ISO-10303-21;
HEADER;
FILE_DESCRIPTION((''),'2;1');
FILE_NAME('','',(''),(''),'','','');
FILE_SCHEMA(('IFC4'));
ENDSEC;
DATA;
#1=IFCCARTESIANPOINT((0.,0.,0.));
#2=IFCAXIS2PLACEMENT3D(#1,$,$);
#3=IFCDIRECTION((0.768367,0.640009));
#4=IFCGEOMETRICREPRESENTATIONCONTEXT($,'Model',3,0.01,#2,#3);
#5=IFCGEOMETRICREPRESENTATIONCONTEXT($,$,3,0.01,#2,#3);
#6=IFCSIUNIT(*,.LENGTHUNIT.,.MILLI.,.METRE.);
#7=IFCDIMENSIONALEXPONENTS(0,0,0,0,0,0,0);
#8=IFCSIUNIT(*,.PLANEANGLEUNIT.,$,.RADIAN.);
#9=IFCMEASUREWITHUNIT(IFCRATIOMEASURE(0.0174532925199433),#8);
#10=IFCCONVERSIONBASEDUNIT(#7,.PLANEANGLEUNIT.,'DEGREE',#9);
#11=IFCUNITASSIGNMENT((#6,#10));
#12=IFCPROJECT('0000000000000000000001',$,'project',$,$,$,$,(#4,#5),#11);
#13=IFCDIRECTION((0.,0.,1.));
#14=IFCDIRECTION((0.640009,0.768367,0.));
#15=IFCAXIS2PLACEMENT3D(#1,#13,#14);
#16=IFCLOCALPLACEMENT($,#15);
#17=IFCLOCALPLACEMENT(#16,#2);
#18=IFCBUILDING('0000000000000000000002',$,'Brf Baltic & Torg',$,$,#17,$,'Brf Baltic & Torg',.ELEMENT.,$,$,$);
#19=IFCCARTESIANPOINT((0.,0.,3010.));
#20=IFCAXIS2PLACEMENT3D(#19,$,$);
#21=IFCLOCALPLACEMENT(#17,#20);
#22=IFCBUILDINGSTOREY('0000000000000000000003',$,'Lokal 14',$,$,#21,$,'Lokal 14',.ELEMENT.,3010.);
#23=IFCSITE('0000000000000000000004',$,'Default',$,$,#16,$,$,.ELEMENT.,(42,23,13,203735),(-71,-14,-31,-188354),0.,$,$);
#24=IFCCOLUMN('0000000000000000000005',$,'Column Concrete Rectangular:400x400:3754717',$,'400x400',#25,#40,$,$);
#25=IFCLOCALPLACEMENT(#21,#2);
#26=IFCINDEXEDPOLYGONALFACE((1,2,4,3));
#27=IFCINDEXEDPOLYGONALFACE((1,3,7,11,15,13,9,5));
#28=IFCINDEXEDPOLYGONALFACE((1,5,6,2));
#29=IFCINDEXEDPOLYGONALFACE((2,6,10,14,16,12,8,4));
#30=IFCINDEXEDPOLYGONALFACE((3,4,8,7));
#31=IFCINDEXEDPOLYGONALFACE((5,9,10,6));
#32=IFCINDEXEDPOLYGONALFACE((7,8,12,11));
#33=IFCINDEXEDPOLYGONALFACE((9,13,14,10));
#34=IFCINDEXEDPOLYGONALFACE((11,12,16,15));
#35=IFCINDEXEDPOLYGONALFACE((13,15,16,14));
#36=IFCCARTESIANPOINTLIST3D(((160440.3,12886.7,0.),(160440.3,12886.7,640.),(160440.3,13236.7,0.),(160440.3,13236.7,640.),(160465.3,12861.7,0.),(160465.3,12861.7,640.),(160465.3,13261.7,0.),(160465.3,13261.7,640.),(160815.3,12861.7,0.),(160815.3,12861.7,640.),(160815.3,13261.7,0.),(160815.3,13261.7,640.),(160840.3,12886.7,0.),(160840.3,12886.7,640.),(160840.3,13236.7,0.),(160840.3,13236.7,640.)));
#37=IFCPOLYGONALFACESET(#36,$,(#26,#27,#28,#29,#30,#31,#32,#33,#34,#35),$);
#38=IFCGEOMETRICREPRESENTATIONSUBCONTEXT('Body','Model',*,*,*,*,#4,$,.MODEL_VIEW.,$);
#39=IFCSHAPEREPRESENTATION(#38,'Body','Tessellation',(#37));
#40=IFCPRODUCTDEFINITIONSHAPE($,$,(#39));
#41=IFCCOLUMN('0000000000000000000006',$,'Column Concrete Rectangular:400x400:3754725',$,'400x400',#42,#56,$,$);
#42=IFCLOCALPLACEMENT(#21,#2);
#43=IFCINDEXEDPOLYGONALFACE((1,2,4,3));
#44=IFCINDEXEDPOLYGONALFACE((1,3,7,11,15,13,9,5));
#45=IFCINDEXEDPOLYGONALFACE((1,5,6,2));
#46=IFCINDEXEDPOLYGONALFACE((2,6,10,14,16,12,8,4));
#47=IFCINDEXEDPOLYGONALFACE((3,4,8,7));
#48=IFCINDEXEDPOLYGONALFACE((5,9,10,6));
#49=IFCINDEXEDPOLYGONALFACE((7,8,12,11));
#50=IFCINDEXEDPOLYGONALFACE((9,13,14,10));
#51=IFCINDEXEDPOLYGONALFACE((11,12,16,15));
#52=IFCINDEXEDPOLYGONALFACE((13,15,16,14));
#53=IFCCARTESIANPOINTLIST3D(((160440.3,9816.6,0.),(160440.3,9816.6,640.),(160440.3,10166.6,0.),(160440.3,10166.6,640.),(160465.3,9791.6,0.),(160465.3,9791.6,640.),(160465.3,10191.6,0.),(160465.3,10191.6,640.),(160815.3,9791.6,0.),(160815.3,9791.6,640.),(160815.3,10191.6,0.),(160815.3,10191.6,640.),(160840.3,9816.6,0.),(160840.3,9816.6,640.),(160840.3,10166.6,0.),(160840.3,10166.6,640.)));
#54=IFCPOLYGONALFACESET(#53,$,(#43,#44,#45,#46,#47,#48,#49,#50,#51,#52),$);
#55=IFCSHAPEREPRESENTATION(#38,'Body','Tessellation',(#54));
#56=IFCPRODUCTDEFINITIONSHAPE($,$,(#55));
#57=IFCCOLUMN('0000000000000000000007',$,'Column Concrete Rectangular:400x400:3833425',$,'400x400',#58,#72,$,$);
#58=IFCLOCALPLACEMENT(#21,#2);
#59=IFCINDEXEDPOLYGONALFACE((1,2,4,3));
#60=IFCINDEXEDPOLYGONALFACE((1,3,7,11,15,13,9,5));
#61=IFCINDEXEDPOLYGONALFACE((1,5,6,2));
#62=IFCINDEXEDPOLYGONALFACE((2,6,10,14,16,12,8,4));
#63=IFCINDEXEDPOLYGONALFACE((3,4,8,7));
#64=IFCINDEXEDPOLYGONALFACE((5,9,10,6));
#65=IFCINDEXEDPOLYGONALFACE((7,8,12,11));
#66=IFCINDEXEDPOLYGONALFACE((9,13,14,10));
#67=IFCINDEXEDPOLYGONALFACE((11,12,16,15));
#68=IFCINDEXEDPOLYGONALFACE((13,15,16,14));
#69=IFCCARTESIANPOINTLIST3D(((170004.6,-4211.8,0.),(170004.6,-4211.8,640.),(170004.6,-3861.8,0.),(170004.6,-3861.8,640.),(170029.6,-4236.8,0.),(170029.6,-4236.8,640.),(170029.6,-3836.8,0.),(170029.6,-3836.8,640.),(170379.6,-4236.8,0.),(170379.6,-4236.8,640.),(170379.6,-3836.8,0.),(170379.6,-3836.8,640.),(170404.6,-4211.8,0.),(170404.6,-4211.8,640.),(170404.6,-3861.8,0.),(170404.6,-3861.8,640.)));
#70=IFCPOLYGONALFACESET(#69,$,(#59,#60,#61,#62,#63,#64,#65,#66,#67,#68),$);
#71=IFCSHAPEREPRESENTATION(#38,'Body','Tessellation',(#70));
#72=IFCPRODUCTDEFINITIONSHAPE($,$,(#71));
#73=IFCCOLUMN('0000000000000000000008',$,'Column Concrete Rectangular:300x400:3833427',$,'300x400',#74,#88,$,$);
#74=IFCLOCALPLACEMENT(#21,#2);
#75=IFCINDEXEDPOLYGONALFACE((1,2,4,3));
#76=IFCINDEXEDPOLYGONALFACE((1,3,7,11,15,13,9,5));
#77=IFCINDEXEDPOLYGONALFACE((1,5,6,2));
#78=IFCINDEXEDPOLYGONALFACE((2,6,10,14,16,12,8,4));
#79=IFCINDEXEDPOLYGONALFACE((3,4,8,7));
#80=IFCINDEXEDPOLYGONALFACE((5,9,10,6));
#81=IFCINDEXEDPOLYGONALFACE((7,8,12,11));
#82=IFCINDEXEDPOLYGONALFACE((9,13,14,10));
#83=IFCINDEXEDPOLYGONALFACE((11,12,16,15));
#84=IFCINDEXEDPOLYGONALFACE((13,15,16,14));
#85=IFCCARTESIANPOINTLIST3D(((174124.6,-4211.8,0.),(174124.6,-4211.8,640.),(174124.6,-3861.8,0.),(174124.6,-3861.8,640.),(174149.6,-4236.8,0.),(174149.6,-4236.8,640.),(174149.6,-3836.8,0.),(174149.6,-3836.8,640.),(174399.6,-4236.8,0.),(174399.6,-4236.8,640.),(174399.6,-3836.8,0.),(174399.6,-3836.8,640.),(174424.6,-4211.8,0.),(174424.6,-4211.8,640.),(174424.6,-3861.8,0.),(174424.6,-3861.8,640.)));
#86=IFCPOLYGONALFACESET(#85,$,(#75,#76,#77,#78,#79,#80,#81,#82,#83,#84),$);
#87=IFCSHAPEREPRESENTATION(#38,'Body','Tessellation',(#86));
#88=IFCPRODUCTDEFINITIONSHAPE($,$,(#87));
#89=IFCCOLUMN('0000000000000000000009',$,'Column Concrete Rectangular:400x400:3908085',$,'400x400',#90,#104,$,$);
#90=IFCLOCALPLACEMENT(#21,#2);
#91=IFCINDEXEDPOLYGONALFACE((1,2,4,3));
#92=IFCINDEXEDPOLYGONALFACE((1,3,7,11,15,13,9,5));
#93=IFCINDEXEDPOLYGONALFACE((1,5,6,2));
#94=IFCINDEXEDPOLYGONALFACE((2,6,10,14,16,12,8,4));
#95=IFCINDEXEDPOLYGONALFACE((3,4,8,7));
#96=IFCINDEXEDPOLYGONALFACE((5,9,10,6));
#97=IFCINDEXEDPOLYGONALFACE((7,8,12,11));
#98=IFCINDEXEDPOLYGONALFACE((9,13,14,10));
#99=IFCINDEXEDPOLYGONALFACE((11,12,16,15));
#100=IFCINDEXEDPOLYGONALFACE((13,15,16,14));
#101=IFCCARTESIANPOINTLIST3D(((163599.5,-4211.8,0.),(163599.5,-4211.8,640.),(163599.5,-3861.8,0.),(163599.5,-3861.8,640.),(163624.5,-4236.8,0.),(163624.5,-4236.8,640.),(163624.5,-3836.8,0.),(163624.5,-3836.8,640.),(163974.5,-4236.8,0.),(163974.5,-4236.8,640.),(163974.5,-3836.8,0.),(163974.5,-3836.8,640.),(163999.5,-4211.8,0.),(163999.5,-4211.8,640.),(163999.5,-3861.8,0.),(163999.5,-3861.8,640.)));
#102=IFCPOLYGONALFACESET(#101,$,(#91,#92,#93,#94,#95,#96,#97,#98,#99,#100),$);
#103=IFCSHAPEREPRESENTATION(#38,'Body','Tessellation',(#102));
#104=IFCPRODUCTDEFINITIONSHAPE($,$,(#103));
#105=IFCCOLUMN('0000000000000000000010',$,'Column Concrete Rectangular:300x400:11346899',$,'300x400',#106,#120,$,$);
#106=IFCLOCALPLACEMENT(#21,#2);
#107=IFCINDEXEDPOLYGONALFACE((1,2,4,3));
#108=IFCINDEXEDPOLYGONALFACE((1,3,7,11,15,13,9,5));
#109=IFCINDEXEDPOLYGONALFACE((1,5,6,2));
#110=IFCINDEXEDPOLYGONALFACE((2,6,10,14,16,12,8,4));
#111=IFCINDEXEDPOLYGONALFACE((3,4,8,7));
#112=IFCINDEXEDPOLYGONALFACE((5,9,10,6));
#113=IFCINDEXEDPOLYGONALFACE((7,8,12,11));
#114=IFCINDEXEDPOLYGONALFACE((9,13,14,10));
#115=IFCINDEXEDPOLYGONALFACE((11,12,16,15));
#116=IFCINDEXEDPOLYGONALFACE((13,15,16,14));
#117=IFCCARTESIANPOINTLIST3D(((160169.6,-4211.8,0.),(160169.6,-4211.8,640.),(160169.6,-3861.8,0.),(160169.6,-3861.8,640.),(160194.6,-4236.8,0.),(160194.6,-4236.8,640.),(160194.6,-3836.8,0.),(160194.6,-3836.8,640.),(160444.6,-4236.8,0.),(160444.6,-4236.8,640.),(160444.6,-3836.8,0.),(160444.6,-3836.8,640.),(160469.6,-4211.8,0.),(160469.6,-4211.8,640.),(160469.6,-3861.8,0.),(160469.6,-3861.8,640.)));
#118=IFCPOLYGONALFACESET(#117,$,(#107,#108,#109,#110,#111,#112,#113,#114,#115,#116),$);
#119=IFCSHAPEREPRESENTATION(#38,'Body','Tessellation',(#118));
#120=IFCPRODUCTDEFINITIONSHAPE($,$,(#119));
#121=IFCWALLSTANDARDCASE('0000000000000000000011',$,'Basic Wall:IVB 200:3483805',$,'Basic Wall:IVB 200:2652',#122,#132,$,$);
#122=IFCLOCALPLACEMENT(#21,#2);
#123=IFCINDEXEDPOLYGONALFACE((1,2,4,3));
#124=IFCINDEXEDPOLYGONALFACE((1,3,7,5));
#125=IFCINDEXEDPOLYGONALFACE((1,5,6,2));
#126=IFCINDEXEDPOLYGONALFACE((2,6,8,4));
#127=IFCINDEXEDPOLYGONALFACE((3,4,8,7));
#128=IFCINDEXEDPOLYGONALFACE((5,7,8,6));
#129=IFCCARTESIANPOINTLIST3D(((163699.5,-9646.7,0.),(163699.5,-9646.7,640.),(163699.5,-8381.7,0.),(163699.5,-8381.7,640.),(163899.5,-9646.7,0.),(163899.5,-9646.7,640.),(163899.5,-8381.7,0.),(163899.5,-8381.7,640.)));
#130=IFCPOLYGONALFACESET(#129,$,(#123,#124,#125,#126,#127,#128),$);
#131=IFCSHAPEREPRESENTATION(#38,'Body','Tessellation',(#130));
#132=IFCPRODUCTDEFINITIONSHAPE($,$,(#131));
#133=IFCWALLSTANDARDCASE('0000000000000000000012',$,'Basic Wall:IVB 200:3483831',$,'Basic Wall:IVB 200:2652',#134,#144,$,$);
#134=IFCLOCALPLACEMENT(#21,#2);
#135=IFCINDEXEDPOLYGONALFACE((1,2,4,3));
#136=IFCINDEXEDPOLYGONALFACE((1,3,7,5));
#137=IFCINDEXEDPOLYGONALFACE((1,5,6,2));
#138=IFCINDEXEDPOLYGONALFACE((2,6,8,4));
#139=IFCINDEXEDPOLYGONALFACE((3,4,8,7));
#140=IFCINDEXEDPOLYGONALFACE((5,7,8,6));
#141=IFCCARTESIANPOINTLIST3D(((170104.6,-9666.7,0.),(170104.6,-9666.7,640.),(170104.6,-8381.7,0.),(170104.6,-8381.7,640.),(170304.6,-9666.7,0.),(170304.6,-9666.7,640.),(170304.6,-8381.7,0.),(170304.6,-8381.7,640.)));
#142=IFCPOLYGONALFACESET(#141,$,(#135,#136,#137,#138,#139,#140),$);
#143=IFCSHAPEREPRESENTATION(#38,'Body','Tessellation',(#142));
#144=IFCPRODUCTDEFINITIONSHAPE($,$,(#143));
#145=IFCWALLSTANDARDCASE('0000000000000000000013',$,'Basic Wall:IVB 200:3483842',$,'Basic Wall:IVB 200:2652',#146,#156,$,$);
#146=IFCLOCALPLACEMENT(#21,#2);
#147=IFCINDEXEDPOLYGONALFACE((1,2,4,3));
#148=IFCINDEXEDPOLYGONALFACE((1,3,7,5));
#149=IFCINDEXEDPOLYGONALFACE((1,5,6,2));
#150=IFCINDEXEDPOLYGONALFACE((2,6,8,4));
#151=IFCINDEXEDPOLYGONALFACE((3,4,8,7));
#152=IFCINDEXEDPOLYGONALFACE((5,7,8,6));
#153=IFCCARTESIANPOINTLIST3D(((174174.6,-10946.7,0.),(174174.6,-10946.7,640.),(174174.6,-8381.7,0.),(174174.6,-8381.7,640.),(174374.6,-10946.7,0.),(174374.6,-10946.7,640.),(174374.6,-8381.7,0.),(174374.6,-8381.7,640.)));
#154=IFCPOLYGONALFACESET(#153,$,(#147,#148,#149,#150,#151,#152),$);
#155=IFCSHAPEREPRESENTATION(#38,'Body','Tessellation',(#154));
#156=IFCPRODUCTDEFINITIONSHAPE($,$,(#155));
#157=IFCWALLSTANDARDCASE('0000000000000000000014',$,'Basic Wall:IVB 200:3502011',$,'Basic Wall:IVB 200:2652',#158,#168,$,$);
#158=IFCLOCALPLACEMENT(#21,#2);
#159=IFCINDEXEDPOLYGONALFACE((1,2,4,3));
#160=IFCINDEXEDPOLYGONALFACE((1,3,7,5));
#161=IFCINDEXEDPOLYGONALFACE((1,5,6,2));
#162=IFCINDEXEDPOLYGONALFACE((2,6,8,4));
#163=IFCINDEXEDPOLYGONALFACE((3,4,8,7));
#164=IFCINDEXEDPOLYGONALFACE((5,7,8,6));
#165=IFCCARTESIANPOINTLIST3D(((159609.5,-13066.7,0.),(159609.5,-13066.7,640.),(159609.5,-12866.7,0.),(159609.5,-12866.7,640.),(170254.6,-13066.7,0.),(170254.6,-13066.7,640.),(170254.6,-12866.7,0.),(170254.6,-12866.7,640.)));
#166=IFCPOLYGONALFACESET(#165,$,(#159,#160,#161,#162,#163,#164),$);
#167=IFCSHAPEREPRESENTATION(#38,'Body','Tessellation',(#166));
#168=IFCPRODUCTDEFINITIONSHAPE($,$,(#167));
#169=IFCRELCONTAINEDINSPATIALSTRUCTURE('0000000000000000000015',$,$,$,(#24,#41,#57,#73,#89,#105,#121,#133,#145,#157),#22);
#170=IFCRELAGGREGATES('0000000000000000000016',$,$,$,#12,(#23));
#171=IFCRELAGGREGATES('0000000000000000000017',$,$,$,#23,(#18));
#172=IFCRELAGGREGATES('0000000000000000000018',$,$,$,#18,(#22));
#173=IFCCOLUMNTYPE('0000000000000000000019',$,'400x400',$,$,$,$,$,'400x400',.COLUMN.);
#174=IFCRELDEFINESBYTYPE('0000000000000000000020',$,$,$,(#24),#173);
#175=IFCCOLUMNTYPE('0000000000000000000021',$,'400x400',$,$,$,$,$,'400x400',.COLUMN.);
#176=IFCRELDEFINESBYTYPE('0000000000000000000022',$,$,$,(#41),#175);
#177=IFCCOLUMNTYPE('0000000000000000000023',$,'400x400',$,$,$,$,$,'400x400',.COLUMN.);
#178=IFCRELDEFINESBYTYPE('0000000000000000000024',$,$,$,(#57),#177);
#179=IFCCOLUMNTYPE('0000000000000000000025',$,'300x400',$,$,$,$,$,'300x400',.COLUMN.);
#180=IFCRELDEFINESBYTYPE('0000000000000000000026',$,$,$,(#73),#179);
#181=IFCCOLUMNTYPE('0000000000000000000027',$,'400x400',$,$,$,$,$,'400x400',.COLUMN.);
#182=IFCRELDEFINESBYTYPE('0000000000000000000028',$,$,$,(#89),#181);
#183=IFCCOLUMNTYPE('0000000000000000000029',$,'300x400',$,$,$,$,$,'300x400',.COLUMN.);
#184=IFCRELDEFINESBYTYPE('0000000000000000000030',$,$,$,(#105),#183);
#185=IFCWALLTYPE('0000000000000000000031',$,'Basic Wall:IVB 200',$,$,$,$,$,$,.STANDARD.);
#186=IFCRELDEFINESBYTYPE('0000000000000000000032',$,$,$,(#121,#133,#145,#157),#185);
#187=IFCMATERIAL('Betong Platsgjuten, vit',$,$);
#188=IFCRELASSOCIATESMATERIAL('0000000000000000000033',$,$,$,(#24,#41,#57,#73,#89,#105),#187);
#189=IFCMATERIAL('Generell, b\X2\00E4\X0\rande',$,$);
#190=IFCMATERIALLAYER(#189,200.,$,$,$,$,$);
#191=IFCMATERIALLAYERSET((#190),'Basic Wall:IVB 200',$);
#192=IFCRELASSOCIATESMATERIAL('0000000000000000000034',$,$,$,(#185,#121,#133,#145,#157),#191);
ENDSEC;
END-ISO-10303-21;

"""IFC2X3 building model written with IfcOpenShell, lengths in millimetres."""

from ifc_helpers import new_model, entity, si_unit, converted_unit, direction, frame, frame_2d, origin, place, context, subcontext, project, spatial, polyline, rectangle, outline, extrude, clip, halfspace, source, transform, mapped, material, layer, layer_set, layer_usage, type_object, type_shapes, element, save


model = new_model("IFC2X3")

# Units and contexts
model_context = context("Model", 3, precision=0.01, world=origin(), true_north=direction((0.768367, 0.640009)))
context_of_model = context(None, 3, precision=0.01, world=origin(), true_north=direction((0.768367, 0.640009)))
body_context = subcontext(model_context, "Body", "Model", "MODEL_VIEW")
ifc_project = project(units=[si_unit("LENGTHUNIT", "METRE", prefix="MILLI"), converted_unit("PLANEANGLEUNIT", "DEGREE", entity("IfcRatioMeasure", 0.0174532925199433), si_unit("PLANEANGLEUNIT", "RADIAN"), dimensions=[0, 0, 0, 0, 0, 0, 0])], contexts=[model_context, context_of_model])

# Site, building, storey
site_placement = place(None, frame((0.0, 0.0, 0.0), z_axis=(0.0, 0.0, 1.0), x_axis=(0.640009, 0.768367, 0.0)))
site = spatial("IfcSite", under=ifc_project, at=site_placement, Name="Default", CompositionType="ELEMENT", RefLatitude=(42, 23, 13, 203735), RefLongitude=(-71, -14, -31, -188354), RefElevation=0.0)
building_placement = place(site_placement, origin())
building = spatial("IfcBuilding", under=site, at=building_placement, Name="Brf Baltic & Torg", LongName="Brf Baltic & Torg", CompositionType="ELEMENT")
storey_placement = place(building_placement, frame((0.0, 0.0, 3010.0)))
storey = spatial("IfcBuildingStorey", under=building, at=storey_placement, Name="Lokal 14", LongName="Lokal 14", CompositionType="ELEMENT", Elevation=3010.0)

# Columns
ifc_material_1 = material(Name="Betong Platsgjuten, vit")
column_type_1 = type_object("IfcColumnType", Name="400x400", ElementType="400x400", PredefinedType="COLUMN")
shared_shape_1 = source(origin(), body_context, "Body", "SweptSolid", [
    extrude(outline(polyline([(-175.0, -200.0), (175.0, -200.0), (200.0, -175.0), (200.0, 175.0), (175.0, 200.0), (-175.0, 200.0), (-200.0, 175.0), (-200.0, -175.0), (-175.0, -200.0)])), frame((0.0, 0.0, 3010.0), z_axis=(0.0, 0.0, 1.0), x_axis=(0.0, -1.0, 0.0)), (0.0, 0.0, 1.0), 640.0),
])
type_shapes(column_type_1, [shared_shape_1])
column_1_placement = place(storey_placement, frame((160640.3, 13061.7, -3010.0)))
element("IfcColumn", 1, at=column_1_placement, inside=storey, type_object=column_type_1, material=ifc_material_1, Name="Column Concrete Rectangular:400x400:3754717", ObjectType="400x400", context=body_context, shape_type="MappedRepresentation", body=[
    mapped(shared_shape_1, transform((0.0, 0.0, 0.0), scale=1.0)),
])
column_type_2 = type_object("IfcColumnType", Name="400x400", ElementType="400x400", PredefinedType="COLUMN")
shared_shape_2 = source(origin(), body_context, "Body", "SweptSolid", [
    extrude(outline(polyline([(-175.0, -200.0), (175.0, -200.0), (200.0, -175.0), (200.0, 175.0), (175.0, 200.0), (-175.0, 200.0), (-200.0, 175.0), (-200.0, -175.0), (-175.0, -200.0)])), frame((0.0, 0.0, 3010.0), z_axis=(0.0, 0.0, 1.0), x_axis=(0.0, -1.0, 0.0)), (0.0, 0.0, 1.0), 640.0),
])
type_shapes(column_type_2, [shared_shape_2])
column_2_placement = place(storey_placement, frame((160640.3, 9991.6, -3010.0)))
element("IfcColumn", 2, at=column_2_placement, inside=storey, type_object=column_type_2, material=ifc_material_1, Name="Column Concrete Rectangular:400x400:3754725", ObjectType="400x400", context=body_context, shape_type="MappedRepresentation", body=[
    mapped(shared_shape_2, transform((0.0, 0.0, 0.0), scale=1.0)),
])
column_type_3 = type_object("IfcColumnType", Name="400x400", ElementType="400x400", PredefinedType="COLUMN")
shared_shape_3 = source(origin(), body_context, "Body", "SweptSolid", [
    extrude(outline(polyline([(-175.0, -200.0), (175.0, -200.0), (200.0, -175.0), (200.0, 175.0), (175.0, 200.0), (-175.0, 200.0), (-200.0, 175.0), (-200.0, -175.0), (-175.0, -200.0)])), frame((0.0, 0.0, 3010.0), z_axis=(0.0, 0.0, 1.0), x_axis=(0.0, -1.0, 0.0)), (0.0, 0.0, 1.0), 640.0),
])
type_shapes(column_type_3, [shared_shape_3])
column_3_placement = place(storey_placement, frame((170204.6, -4036.8, -3010.0)))
element("IfcColumn", 3, at=column_3_placement, inside=storey, type_object=column_type_3, material=ifc_material_1, Name="Column Concrete Rectangular:400x400:3833425", ObjectType="400x400", context=body_context, shape_type="MappedRepresentation", body=[
    mapped(shared_shape_3, transform((0.0, 0.0, 0.0), scale=1.0)),
])
column_type_4 = type_object("IfcColumnType", Name="300x400", ElementType="300x400", PredefinedType="COLUMN")
shared_shape_4 = source(origin(), body_context, "Body", "SweptSolid", [
    extrude(outline(polyline([(-175.0, -150.0), (175.0, -150.0), (200.0, -125.0), (200.0, 125.0), (175.0, 150.0), (-175.0, 150.0), (-200.0, 125.0), (-200.0, -125.0), (-175.0, -150.0)])), frame((0.0, 0.0, 3010.0), z_axis=(0.0, 0.0, 1.0), x_axis=(0.0, -1.0, 0.0)), (0.0, 0.0, 1.0), 640.0),
])
type_shapes(column_type_4, [shared_shape_4])
column_4_placement = place(storey_placement, frame((174274.6, -4036.8, -3010.0)))
element("IfcColumn", 4, at=column_4_placement, inside=storey, type_object=column_type_4, material=ifc_material_1, Name="Column Concrete Rectangular:300x400:3833427", ObjectType="300x400", context=body_context, shape_type="MappedRepresentation", body=[
    mapped(shared_shape_4, transform((0.0, 0.0, 0.0), scale=1.0)),
])
column_type_5 = type_object("IfcColumnType", Name="400x400", ElementType="400x400", PredefinedType="COLUMN")
shared_shape_5 = source(origin(), body_context, "Body", "SweptSolid", [
    extrude(outline(polyline([(-175.0, -200.0), (175.0, -200.0), (200.0, -175.0), (200.0, 175.0), (175.0, 200.0), (-175.0, 200.0), (-200.0, 175.0), (-200.0, -175.0), (-175.0, -200.0)])), frame((0.0, 0.0, 3010.0), z_axis=(0.0, 0.0, 1.0), x_axis=(0.0, -1.0, 0.0)), (0.0, 0.0, 1.0), 640.0),
])
type_shapes(column_type_5, [shared_shape_5])
column_5_placement = place(storey_placement, frame((163799.5, -4036.8, -3010.0)))
element("IfcColumn", 5, at=column_5_placement, inside=storey, type_object=column_type_5, material=ifc_material_1, Name="Column Concrete Rectangular:400x400:3908085", ObjectType="400x400", context=body_context, shape_type="MappedRepresentation", body=[
    mapped(shared_shape_5, transform((0.0, 0.0, 0.0), scale=1.0)),
])
column_type_6 = type_object("IfcColumnType", Name="300x400", ElementType="300x400", PredefinedType="COLUMN")
shared_shape_6 = source(origin(), body_context, "Body", "SweptSolid", [
    extrude(outline(polyline([(-175.0, -150.0), (175.0, -150.0), (200.0, -125.0), (200.0, 125.0), (175.0, 150.0), (-175.0, 150.0), (-200.0, 125.0), (-200.0, -125.0), (-175.0, -150.0)])), frame((0.0, 0.0, 3010.0), z_axis=(0.0, 0.0, 1.0), x_axis=(0.0, -1.0, 0.0)), (0.0, 0.0, 1.0), 640.0),
])
type_shapes(column_type_6, [shared_shape_6])
column_6_placement = place(storey_placement, frame((160319.6, -4036.8, -3010.0)))
element("IfcColumn", 6, at=column_6_placement, inside=storey, type_object=column_type_6, material=ifc_material_1, Name="Column Concrete Rectangular:300x400:11346899", ObjectType="300x400", context=body_context, shape_type="MappedRepresentation", body=[
    mapped(shared_shape_6, transform((0.0, 0.0, 0.0), scale=1.0)),
])

# Shared definitions
ifc_material_2 = material(Name="Generell, bärande")
ifc_layer = layer(ifc_material_2, 200.0)
ifc_layer_set = layer_set([ifc_layer], Name="Basic Wall:IVB 200")
wall_type = type_object("IfcWallType", Name="Basic Wall:IVB 200", PredefinedType="STANDARD", material=ifc_layer_set)

# Walls
ifc_layer_usage_1 = layer_usage(ifc_layer_set, "AXIS2", "POSITIVE", -100.0)
wall_1_placement = place(storey_placement, frame((163799.5, -8381.7, 0.0), z_axis=(0.0, 0.0, 1.0), x_axis=(0.0, -1.0, 0.0)))
element("IfcWallStandardCase", 7, at=wall_1_placement, inside=storey, type_object=wall_type, material=ifc_layer_usage_1, Name="Basic Wall:IVB 200:3483805", ObjectType="Basic Wall:IVB 200:2652", context=body_context, shape_type="Clipping", body=[
    clip(extrude(rectangle(XDim=1265.0, YDim=200.0, at=frame_2d((632.5, 0.0), x_axis=(-1.0, 0.0))), origin(), (0.0, 0.0, 1.0), 640.0), halfspace(frame((0.0, 0.0, -1360.0)), True)),
])
ifc_layer_usage_2 = layer_usage(ifc_layer_set, "AXIS2", "POSITIVE", -100.0)
wall_2_placement = place(storey_placement, frame((170204.6, -8381.7, 0.0), z_axis=(0.0, 0.0, 1.0), x_axis=(0.0, -1.0, 0.0)))
element("IfcWallStandardCase", 8, at=wall_2_placement, inside=storey, type_object=wall_type, material=ifc_layer_usage_2, Name="Basic Wall:IVB 200:3483831", ObjectType="Basic Wall:IVB 200:2652", context=body_context, shape_type="Clipping", body=[
    clip(extrude(rectangle(XDim=1285.0, YDim=200.0, at=frame_2d((642.5, 0.0), x_axis=(-1.0, 0.0))), origin(), (0.0, 0.0, 1.0), 640.0), halfspace(frame((0.0, 0.0, -1360.0)), True)),
])
ifc_layer_usage_3 = layer_usage(ifc_layer_set, "AXIS2", "POSITIVE", -100.0)
wall_3_placement = place(storey_placement, frame((174274.6, -8381.7, 0.0), z_axis=(0.0, 0.0, 1.0), x_axis=(0.0, -1.0, 0.0)))
element("IfcWallStandardCase", 9, at=wall_3_placement, inside=storey, type_object=wall_type, material=ifc_layer_usage_3, Name="Basic Wall:IVB 200:3483842", ObjectType="Basic Wall:IVB 200:2652", context=body_context, shape_type="Clipping", body=[
    clip(extrude(rectangle(XDim=2565.0, YDim=200.0, at=frame_2d((1282.5, 0.0), x_axis=(-1.0, 0.0))), origin(), (0.0, 0.0, 1.0), 640.0), halfspace(frame((0.0, 0.0, -1360.0)), True)),
])
ifc_layer_usage_4 = layer_usage(ifc_layer_set, "AXIS2", "NEGATIVE", 100.0)
wall_4_placement = place(storey_placement, frame((170254.6, -12966.7, 0.0), z_axis=(0.0, 0.0, 1.0), x_axis=(-1.0, 0.0, 0.0)))
element("IfcWallStandardCase", 10, at=wall_4_placement, inside=storey, type_object=wall_type, material=ifc_layer_usage_4, Name="Basic Wall:IVB 200:3502011", ObjectType="Basic Wall:IVB 200:2652", context=body_context, shape_type="Clipping", body=[
    clip(extrude(rectangle(XDim=10645.0, YDim=200.0, at=frame_2d((5322.5, 0.0), x_axis=(-1.0, 0.0))), origin(), (0.0, 0.0, 1.0), 640.0), halfspace(frame((0.0, 0.0, -1360.0)), True)),
])

save(model, "model.ifc")
